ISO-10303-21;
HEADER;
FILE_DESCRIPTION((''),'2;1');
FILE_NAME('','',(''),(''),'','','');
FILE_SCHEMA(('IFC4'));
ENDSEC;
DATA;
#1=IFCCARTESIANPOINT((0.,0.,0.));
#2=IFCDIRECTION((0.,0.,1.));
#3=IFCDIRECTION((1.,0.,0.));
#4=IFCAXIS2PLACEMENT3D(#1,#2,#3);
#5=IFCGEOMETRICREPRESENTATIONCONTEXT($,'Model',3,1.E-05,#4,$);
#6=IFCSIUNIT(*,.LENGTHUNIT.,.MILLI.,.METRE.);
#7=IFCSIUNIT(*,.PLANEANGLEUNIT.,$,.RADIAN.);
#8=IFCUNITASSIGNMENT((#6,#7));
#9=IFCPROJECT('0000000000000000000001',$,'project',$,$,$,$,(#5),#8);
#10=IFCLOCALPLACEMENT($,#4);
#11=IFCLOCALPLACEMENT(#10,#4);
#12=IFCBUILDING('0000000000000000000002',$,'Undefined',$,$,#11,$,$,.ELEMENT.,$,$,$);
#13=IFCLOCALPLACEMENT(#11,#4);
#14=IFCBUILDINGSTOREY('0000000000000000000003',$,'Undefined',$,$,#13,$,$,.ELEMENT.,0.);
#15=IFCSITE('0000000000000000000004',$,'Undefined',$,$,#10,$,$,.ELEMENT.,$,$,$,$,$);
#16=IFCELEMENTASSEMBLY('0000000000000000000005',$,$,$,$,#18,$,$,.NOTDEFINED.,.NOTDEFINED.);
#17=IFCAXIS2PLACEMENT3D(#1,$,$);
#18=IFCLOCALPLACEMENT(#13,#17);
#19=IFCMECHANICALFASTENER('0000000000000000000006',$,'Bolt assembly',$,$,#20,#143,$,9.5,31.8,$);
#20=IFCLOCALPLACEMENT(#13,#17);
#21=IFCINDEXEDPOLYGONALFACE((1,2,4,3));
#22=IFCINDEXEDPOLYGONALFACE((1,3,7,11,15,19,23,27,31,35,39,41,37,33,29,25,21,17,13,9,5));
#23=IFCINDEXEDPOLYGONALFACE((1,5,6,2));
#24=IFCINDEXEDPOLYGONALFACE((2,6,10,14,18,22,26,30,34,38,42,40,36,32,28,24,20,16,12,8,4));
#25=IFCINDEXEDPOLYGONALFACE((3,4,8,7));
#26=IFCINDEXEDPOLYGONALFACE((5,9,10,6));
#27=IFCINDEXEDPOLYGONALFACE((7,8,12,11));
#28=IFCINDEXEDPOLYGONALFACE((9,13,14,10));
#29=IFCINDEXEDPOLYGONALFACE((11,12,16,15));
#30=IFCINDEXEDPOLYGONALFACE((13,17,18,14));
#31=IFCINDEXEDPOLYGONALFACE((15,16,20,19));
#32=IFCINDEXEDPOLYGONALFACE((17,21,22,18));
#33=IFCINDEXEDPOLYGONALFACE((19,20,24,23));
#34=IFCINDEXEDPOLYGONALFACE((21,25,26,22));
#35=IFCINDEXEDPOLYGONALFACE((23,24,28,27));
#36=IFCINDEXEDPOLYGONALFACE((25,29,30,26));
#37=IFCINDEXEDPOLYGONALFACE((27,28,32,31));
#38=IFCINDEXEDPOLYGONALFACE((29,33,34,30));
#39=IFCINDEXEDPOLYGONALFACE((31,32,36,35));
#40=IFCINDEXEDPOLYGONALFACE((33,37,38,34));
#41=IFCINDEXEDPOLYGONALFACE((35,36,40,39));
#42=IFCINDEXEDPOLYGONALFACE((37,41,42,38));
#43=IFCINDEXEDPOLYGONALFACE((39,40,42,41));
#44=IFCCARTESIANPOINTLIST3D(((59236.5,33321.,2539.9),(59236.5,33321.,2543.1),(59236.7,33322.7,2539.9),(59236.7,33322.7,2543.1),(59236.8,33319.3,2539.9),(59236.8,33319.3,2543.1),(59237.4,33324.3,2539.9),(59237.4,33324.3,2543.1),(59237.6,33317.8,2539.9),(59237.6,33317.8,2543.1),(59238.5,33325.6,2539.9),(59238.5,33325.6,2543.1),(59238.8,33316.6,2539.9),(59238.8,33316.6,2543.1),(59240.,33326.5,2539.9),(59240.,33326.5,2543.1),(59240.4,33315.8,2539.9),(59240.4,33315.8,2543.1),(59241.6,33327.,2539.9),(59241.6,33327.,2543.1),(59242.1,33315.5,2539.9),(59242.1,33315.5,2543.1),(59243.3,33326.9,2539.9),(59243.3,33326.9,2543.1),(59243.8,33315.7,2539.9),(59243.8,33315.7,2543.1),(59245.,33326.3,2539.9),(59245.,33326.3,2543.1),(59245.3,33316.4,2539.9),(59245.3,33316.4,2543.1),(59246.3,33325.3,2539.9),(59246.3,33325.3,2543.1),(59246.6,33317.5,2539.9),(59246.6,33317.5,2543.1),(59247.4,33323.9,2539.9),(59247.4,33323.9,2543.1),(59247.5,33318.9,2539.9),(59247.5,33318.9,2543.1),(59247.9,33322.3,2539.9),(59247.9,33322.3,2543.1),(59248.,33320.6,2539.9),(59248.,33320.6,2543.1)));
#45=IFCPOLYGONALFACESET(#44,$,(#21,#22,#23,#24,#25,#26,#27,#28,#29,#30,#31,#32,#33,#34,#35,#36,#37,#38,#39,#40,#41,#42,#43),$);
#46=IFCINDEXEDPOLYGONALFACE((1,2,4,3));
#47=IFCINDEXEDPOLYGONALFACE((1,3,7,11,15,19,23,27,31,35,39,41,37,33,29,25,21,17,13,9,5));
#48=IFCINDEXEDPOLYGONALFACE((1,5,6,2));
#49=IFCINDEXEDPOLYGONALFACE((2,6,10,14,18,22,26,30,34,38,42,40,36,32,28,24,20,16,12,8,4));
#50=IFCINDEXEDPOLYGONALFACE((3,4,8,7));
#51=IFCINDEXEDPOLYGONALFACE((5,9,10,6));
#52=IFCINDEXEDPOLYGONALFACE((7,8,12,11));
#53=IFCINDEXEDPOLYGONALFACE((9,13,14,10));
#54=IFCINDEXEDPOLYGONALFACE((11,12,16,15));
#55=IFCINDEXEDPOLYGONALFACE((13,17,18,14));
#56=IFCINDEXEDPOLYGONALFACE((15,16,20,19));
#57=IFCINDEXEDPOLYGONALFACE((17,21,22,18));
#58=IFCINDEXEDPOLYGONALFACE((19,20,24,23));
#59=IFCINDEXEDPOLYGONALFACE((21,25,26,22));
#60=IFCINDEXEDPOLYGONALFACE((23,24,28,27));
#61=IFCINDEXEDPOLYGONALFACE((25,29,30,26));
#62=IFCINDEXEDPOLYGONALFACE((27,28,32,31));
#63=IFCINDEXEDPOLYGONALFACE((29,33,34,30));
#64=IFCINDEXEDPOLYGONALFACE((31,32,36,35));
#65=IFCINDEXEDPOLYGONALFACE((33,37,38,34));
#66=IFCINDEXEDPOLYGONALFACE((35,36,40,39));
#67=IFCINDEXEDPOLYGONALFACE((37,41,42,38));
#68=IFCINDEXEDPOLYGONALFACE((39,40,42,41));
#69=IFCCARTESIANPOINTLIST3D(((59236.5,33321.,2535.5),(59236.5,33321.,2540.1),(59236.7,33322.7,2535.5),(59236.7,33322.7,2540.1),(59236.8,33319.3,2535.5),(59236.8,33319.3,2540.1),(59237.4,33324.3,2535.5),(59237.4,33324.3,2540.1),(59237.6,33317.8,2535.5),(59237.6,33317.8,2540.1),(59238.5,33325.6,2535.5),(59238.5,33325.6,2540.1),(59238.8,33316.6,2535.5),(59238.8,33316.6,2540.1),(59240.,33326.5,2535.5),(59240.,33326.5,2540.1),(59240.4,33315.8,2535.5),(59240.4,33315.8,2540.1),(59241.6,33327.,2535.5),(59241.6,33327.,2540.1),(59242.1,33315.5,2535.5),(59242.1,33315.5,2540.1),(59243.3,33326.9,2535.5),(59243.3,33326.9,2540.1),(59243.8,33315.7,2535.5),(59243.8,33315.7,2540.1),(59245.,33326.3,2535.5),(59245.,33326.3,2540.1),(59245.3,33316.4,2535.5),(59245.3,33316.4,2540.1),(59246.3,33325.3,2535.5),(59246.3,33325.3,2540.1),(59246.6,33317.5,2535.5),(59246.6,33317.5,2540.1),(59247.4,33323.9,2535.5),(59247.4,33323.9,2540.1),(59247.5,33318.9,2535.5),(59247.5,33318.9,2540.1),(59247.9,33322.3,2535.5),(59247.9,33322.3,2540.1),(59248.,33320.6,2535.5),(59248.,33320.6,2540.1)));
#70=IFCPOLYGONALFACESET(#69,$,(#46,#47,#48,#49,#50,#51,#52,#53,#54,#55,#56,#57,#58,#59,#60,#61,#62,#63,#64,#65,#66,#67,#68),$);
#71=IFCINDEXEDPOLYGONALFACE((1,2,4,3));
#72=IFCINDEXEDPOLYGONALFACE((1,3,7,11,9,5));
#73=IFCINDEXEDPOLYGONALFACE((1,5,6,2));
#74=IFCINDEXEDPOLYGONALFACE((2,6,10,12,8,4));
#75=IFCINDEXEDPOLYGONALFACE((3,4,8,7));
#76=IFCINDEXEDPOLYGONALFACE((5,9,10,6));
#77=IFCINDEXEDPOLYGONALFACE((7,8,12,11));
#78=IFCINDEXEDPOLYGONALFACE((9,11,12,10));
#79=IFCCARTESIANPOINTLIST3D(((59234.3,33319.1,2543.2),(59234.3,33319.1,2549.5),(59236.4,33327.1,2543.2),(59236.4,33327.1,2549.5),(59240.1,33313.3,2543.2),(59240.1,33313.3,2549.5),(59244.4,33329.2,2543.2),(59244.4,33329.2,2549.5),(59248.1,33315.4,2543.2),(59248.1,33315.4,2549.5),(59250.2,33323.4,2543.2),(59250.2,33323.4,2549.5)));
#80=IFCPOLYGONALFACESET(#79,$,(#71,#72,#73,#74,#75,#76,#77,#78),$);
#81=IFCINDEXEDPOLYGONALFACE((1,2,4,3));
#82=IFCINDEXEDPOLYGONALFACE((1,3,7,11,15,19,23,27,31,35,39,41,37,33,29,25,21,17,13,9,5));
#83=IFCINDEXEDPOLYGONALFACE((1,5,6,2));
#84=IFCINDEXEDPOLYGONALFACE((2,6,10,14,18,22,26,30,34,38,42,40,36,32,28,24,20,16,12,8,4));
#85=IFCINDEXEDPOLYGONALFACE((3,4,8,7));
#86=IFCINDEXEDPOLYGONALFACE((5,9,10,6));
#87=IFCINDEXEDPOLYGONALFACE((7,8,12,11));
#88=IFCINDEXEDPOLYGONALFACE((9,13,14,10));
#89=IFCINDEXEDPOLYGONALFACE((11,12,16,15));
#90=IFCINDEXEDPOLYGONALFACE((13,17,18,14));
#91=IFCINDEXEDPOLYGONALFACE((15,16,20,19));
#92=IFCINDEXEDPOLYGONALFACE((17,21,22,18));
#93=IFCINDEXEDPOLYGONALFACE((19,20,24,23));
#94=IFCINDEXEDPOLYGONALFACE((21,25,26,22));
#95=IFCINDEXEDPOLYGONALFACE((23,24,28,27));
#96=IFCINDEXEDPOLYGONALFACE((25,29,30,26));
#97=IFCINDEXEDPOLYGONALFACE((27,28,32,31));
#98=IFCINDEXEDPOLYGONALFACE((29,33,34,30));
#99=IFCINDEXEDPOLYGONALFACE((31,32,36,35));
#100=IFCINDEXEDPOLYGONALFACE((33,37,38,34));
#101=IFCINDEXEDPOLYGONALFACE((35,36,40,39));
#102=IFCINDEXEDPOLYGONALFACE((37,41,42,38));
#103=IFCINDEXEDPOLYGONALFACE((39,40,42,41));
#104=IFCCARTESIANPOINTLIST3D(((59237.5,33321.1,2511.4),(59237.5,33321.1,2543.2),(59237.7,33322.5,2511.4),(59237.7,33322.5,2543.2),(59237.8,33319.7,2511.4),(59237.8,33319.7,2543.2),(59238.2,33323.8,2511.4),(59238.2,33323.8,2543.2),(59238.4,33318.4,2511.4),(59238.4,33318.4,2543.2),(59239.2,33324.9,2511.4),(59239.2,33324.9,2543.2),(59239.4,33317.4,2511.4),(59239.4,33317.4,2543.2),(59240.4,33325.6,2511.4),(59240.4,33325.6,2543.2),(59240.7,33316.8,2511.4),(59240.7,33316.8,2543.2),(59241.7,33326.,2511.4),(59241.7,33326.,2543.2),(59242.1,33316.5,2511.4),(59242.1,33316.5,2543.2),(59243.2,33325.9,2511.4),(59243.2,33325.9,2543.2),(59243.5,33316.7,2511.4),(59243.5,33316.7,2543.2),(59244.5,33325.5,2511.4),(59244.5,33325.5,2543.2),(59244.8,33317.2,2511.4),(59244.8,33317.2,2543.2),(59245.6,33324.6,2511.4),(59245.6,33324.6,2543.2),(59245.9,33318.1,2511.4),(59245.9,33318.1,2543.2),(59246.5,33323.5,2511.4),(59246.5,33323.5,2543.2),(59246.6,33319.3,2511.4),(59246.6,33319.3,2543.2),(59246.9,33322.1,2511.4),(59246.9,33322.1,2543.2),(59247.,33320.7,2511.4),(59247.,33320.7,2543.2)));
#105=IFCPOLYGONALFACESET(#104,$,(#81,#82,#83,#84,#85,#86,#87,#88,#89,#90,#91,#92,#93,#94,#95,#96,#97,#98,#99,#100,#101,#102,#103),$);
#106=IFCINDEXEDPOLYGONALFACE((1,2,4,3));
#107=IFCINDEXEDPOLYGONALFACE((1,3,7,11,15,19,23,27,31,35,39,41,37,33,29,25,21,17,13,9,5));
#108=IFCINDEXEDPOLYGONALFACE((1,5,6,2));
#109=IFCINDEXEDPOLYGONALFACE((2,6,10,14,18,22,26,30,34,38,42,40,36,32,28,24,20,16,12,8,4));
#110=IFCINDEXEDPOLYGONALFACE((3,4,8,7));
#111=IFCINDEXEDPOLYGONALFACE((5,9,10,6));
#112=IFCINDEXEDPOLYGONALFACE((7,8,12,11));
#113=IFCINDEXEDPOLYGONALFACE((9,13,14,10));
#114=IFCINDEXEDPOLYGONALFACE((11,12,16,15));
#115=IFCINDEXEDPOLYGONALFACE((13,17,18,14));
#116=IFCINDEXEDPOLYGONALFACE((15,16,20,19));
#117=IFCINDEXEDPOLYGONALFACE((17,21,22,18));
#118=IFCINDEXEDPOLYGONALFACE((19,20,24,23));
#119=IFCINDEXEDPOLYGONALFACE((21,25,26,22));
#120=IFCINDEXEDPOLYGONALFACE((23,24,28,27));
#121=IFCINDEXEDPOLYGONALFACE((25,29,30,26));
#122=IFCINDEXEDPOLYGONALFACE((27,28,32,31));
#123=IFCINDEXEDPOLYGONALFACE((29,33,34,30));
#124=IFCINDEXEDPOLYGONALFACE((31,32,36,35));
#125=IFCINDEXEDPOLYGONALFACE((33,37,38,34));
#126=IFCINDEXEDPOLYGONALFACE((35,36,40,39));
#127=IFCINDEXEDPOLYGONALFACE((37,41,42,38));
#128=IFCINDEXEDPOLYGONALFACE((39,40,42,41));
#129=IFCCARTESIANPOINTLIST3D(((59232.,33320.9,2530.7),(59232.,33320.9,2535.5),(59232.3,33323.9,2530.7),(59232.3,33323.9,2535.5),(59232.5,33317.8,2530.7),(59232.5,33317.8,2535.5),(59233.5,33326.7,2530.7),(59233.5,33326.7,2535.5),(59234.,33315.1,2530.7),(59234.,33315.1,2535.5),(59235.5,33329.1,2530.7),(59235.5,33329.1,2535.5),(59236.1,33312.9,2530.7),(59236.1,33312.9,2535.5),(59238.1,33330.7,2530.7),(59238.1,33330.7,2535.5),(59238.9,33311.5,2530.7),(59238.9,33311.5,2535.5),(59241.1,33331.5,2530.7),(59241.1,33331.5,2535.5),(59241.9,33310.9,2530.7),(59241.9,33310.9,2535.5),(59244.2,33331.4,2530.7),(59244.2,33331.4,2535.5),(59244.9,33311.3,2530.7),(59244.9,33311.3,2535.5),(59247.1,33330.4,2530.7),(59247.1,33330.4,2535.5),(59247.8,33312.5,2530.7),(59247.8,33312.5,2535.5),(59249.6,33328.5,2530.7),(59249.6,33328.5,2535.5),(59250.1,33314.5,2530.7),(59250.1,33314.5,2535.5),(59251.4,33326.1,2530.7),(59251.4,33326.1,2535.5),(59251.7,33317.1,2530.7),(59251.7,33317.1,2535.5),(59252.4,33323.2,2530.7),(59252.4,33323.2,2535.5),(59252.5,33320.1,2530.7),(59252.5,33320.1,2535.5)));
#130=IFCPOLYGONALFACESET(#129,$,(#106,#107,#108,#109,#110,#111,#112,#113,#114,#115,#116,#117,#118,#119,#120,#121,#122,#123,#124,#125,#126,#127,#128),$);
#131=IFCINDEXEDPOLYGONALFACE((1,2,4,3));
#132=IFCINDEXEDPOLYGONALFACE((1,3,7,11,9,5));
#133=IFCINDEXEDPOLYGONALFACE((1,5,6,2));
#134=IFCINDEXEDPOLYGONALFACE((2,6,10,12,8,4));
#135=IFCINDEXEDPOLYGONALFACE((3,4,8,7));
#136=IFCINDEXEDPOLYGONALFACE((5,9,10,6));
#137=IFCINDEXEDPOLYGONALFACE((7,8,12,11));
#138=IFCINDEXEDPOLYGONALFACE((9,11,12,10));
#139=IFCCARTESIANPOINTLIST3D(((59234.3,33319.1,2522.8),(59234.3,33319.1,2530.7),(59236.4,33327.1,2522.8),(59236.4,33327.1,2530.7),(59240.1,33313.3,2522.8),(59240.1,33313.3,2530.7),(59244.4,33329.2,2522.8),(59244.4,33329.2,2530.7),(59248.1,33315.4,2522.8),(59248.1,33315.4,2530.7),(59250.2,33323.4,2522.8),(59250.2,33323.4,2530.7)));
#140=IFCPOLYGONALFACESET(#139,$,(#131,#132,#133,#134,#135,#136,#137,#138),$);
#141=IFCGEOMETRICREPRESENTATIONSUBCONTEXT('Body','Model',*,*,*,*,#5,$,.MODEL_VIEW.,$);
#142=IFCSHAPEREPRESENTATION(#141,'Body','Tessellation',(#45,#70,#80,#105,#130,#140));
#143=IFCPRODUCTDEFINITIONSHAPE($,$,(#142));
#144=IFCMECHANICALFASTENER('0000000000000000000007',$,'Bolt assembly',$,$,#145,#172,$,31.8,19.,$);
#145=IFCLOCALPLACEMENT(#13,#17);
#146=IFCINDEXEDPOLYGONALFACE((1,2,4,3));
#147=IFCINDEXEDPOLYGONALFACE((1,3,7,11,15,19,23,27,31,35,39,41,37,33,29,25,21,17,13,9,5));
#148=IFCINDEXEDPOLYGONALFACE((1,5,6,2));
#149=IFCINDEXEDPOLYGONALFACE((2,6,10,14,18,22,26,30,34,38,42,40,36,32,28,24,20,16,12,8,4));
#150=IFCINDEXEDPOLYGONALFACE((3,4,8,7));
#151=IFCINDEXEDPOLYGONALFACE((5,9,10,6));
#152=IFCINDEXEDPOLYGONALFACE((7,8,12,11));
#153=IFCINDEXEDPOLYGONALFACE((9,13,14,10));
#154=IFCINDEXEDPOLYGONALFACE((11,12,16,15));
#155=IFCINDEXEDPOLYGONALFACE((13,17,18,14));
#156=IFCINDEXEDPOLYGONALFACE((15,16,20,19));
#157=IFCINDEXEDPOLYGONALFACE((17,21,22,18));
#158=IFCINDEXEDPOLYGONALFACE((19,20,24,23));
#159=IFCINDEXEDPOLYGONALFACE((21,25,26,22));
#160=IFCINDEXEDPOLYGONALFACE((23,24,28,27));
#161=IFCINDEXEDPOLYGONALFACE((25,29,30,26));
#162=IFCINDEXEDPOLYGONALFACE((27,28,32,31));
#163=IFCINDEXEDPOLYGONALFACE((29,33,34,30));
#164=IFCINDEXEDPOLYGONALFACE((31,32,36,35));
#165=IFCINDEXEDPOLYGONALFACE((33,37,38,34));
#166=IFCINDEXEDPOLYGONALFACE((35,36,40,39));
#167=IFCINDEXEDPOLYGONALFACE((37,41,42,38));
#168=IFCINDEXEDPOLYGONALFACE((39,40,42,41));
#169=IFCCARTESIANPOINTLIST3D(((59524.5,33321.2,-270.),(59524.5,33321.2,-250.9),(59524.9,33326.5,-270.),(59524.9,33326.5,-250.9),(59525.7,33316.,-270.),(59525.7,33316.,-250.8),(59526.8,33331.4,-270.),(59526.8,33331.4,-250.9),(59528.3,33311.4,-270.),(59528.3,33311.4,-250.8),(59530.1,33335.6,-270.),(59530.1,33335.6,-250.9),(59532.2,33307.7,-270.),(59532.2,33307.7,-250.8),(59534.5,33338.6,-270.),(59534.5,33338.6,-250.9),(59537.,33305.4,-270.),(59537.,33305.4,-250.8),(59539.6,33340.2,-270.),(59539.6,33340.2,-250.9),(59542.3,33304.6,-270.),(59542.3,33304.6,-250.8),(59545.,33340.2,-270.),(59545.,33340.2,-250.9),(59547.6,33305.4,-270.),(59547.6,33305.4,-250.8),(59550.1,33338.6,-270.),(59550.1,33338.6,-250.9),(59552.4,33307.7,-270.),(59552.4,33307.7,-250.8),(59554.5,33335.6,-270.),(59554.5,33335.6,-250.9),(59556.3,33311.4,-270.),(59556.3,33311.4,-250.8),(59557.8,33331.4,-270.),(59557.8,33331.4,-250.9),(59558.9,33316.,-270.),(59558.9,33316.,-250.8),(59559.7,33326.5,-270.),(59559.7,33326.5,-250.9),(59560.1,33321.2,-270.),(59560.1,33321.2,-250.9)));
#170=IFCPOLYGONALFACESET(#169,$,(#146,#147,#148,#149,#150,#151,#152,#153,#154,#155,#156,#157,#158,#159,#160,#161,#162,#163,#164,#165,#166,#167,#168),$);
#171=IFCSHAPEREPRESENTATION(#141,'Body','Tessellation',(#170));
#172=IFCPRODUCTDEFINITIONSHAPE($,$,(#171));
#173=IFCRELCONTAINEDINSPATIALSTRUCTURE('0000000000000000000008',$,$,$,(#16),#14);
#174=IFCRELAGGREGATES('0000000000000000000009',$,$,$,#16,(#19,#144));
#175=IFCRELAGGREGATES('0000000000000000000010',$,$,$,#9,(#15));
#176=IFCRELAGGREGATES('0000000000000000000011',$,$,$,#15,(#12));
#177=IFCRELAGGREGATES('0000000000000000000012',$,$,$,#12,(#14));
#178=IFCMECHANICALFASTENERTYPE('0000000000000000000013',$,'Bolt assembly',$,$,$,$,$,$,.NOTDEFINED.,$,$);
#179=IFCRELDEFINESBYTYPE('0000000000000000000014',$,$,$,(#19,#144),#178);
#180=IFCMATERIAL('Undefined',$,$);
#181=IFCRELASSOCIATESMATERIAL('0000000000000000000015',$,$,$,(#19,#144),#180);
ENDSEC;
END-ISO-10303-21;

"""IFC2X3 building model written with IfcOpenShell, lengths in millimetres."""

from ifc_helpers import new_model, si_unit, frame, origin_with_axes, origin_2d_with_axis, place, context, subcontext, project, spatial, polyline, circle, outline, extrude, source, transform, mapped, material, type_object, element, aggregate, save


model = new_model("IFC2X3")

# Units and contexts
model_context = context("Model", 3, precision=1e-05, world=origin_with_axes())
body_context = subcontext(model_context, "Body", "Model", "MODEL_VIEW")
ifc_project = project(units=[si_unit("LENGTHUNIT", "METRE", prefix="MILLI"), si_unit("PLANEANGLEUNIT", "RADIAN")], contexts=[model_context])

# Site, building, storey
site_placement = place(None, origin_with_axes())
site = spatial("IfcSite", under=ifc_project, at=site_placement, Name="Undefined", CompositionType="ELEMENT")
building_placement = place(site_placement, origin_with_axes())
building = spatial("IfcBuilding", under=site, at=building_placement, Name="Undefined", CompositionType="ELEMENT")
storey_placement = place(building_placement, origin_with_axes())
storey = spatial("IfcBuildingStorey", under=building, at=storey_placement, Name="Undefined", CompositionType="ELEMENT", Elevation=0.0)

# Element assembly
assembly_1_placement = place(storey_placement, origin_with_axes())
assembly_1 = element("IfcElementAssembly", 1, at=assembly_1_placement, inside=storey, AssemblyPlace="NOTDEFINED", PredefinedType="NOTDEFINED")

# Shared definitions
ifc_material_1 = material(Name="Undefined")
mechanical_fastener_type = type_object("IfcMechanicalFastenerType", Name="Bolt assembly")

# Mechanical fasteners
shared_shape_1 = source(origin_with_axes(), body_context, "Body", "SweptSolid", [
    extrude(circle(Radius=5.8, at=origin_2d_with_axis()), frame((0.0, -7.6, 0.0), z_axis=(0.0, 1.0, 0.0), x_axis=(1.0, 0.0, 0.0)), (0.0, 0.0, 1.0), 3.2),
    extrude(circle(Radius=5.8, at=origin_2d_with_axis()), frame((0.0, -4.6, 0.0), z_axis=(0.0, 1.0, 0.0), x_axis=(1.0, 0.0, 0.0)), (0.0, 0.0, 1.0), 4.6),
    extrude(outline(polyline([(7.1, -4.1), (7.1, 4.1), (0.0, 8.2), (-7.1, 4.1), (-7.1, -4.1), (0.0, -8.2), (7.1, -4.1)])), frame((0.0, -14.0, 0.0), z_axis=(0.0, 1.0, 0.0), x_axis=(1.0, 0.0, 0.0)), (0.0, 0.0, 1.0), 6.3),
    extrude(circle(Radius=4.8, at=origin_2d_with_axis()), frame((0.0, -7.7, 0.0), z_axis=(0.0, 1.0, 0.0), x_axis=(1.0, 0.0, 0.0)), (0.0, 0.0, 1.0), 31.8),
    extrude(circle(Radius=10.3, at=origin_2d_with_axis()), frame((0.0, 0.0, 0.0), z_axis=(0.0, 1.0, 0.0), x_axis=(1.0, 0.0, 0.0)), (0.0, 0.0, 1.0), 4.8),
    extrude(outline(polyline([(7.1, -4.1), (7.1, 4.1), (0.0, 8.2), (-7.1, 4.1), (-7.1, -4.1), (0.0, -8.2), (7.1, -4.1)])), frame((0.0, 4.8, 0.0), z_axis=(0.0, 1.0, 0.0), x_axis=(1.0, 0.0, 0.0)), (0.0, 0.0, 1.0), 7.9),
])
mechanical_fastener_1_placement = place(assembly_1_placement, frame((59242.3, 33321.3, 2535.5), z_axis=(-0.707107, 0.707107, 0.0), x_axis=(0.707107, 0.707107, 0.0)))
mechanical_fastener_1 = element("IfcMechanicalFastener", 2, at=mechanical_fastener_1_placement, type_object=mechanical_fastener_type, material=ifc_material_1, Name="Bolt assembly", NominalDiameter=9.5, NominalLength=31.8, context=body_context, shape_type="MappedRepresentation", body=[
    mapped(shared_shape_1, transform((0.0, 0.0, 0.0))),
])
shared_shape_2 = source(origin_with_axes(), body_context, "Body", "SweptSolid", [
    extrude(circle(Radius=17.9, at=origin_2d_with_axis()), frame((0.0, -19.1, 0.0), z_axis=(0.0, 1.0, 0.0), x_axis=(1.0, 0.0, 0.0)), (0.0, 0.0, 1.0), 19.1),
])
mechanical_fastener_2_placement = place(assembly_1_placement, frame((59542.3, 33322.5, -250.9), z_axis=(-1.0, 0.0, 0.0), x_axis=(0.0, -1.0, 0.0)))
mechanical_fastener_2 = element("IfcMechanicalFastener", 3, at=mechanical_fastener_2_placement, type_object=mechanical_fastener_type, material=ifc_material_1, Name="Bolt assembly", NominalDiameter=31.8, NominalLength=19.0, context=body_context, shape_type="MappedRepresentation", body=[
    mapped(shared_shape_2, transform((0.0, 0.0, 0.0))),
])
aggregate(assembly_1, [mechanical_fastener_1, mechanical_fastener_2])

save(model, "model.ifc")
